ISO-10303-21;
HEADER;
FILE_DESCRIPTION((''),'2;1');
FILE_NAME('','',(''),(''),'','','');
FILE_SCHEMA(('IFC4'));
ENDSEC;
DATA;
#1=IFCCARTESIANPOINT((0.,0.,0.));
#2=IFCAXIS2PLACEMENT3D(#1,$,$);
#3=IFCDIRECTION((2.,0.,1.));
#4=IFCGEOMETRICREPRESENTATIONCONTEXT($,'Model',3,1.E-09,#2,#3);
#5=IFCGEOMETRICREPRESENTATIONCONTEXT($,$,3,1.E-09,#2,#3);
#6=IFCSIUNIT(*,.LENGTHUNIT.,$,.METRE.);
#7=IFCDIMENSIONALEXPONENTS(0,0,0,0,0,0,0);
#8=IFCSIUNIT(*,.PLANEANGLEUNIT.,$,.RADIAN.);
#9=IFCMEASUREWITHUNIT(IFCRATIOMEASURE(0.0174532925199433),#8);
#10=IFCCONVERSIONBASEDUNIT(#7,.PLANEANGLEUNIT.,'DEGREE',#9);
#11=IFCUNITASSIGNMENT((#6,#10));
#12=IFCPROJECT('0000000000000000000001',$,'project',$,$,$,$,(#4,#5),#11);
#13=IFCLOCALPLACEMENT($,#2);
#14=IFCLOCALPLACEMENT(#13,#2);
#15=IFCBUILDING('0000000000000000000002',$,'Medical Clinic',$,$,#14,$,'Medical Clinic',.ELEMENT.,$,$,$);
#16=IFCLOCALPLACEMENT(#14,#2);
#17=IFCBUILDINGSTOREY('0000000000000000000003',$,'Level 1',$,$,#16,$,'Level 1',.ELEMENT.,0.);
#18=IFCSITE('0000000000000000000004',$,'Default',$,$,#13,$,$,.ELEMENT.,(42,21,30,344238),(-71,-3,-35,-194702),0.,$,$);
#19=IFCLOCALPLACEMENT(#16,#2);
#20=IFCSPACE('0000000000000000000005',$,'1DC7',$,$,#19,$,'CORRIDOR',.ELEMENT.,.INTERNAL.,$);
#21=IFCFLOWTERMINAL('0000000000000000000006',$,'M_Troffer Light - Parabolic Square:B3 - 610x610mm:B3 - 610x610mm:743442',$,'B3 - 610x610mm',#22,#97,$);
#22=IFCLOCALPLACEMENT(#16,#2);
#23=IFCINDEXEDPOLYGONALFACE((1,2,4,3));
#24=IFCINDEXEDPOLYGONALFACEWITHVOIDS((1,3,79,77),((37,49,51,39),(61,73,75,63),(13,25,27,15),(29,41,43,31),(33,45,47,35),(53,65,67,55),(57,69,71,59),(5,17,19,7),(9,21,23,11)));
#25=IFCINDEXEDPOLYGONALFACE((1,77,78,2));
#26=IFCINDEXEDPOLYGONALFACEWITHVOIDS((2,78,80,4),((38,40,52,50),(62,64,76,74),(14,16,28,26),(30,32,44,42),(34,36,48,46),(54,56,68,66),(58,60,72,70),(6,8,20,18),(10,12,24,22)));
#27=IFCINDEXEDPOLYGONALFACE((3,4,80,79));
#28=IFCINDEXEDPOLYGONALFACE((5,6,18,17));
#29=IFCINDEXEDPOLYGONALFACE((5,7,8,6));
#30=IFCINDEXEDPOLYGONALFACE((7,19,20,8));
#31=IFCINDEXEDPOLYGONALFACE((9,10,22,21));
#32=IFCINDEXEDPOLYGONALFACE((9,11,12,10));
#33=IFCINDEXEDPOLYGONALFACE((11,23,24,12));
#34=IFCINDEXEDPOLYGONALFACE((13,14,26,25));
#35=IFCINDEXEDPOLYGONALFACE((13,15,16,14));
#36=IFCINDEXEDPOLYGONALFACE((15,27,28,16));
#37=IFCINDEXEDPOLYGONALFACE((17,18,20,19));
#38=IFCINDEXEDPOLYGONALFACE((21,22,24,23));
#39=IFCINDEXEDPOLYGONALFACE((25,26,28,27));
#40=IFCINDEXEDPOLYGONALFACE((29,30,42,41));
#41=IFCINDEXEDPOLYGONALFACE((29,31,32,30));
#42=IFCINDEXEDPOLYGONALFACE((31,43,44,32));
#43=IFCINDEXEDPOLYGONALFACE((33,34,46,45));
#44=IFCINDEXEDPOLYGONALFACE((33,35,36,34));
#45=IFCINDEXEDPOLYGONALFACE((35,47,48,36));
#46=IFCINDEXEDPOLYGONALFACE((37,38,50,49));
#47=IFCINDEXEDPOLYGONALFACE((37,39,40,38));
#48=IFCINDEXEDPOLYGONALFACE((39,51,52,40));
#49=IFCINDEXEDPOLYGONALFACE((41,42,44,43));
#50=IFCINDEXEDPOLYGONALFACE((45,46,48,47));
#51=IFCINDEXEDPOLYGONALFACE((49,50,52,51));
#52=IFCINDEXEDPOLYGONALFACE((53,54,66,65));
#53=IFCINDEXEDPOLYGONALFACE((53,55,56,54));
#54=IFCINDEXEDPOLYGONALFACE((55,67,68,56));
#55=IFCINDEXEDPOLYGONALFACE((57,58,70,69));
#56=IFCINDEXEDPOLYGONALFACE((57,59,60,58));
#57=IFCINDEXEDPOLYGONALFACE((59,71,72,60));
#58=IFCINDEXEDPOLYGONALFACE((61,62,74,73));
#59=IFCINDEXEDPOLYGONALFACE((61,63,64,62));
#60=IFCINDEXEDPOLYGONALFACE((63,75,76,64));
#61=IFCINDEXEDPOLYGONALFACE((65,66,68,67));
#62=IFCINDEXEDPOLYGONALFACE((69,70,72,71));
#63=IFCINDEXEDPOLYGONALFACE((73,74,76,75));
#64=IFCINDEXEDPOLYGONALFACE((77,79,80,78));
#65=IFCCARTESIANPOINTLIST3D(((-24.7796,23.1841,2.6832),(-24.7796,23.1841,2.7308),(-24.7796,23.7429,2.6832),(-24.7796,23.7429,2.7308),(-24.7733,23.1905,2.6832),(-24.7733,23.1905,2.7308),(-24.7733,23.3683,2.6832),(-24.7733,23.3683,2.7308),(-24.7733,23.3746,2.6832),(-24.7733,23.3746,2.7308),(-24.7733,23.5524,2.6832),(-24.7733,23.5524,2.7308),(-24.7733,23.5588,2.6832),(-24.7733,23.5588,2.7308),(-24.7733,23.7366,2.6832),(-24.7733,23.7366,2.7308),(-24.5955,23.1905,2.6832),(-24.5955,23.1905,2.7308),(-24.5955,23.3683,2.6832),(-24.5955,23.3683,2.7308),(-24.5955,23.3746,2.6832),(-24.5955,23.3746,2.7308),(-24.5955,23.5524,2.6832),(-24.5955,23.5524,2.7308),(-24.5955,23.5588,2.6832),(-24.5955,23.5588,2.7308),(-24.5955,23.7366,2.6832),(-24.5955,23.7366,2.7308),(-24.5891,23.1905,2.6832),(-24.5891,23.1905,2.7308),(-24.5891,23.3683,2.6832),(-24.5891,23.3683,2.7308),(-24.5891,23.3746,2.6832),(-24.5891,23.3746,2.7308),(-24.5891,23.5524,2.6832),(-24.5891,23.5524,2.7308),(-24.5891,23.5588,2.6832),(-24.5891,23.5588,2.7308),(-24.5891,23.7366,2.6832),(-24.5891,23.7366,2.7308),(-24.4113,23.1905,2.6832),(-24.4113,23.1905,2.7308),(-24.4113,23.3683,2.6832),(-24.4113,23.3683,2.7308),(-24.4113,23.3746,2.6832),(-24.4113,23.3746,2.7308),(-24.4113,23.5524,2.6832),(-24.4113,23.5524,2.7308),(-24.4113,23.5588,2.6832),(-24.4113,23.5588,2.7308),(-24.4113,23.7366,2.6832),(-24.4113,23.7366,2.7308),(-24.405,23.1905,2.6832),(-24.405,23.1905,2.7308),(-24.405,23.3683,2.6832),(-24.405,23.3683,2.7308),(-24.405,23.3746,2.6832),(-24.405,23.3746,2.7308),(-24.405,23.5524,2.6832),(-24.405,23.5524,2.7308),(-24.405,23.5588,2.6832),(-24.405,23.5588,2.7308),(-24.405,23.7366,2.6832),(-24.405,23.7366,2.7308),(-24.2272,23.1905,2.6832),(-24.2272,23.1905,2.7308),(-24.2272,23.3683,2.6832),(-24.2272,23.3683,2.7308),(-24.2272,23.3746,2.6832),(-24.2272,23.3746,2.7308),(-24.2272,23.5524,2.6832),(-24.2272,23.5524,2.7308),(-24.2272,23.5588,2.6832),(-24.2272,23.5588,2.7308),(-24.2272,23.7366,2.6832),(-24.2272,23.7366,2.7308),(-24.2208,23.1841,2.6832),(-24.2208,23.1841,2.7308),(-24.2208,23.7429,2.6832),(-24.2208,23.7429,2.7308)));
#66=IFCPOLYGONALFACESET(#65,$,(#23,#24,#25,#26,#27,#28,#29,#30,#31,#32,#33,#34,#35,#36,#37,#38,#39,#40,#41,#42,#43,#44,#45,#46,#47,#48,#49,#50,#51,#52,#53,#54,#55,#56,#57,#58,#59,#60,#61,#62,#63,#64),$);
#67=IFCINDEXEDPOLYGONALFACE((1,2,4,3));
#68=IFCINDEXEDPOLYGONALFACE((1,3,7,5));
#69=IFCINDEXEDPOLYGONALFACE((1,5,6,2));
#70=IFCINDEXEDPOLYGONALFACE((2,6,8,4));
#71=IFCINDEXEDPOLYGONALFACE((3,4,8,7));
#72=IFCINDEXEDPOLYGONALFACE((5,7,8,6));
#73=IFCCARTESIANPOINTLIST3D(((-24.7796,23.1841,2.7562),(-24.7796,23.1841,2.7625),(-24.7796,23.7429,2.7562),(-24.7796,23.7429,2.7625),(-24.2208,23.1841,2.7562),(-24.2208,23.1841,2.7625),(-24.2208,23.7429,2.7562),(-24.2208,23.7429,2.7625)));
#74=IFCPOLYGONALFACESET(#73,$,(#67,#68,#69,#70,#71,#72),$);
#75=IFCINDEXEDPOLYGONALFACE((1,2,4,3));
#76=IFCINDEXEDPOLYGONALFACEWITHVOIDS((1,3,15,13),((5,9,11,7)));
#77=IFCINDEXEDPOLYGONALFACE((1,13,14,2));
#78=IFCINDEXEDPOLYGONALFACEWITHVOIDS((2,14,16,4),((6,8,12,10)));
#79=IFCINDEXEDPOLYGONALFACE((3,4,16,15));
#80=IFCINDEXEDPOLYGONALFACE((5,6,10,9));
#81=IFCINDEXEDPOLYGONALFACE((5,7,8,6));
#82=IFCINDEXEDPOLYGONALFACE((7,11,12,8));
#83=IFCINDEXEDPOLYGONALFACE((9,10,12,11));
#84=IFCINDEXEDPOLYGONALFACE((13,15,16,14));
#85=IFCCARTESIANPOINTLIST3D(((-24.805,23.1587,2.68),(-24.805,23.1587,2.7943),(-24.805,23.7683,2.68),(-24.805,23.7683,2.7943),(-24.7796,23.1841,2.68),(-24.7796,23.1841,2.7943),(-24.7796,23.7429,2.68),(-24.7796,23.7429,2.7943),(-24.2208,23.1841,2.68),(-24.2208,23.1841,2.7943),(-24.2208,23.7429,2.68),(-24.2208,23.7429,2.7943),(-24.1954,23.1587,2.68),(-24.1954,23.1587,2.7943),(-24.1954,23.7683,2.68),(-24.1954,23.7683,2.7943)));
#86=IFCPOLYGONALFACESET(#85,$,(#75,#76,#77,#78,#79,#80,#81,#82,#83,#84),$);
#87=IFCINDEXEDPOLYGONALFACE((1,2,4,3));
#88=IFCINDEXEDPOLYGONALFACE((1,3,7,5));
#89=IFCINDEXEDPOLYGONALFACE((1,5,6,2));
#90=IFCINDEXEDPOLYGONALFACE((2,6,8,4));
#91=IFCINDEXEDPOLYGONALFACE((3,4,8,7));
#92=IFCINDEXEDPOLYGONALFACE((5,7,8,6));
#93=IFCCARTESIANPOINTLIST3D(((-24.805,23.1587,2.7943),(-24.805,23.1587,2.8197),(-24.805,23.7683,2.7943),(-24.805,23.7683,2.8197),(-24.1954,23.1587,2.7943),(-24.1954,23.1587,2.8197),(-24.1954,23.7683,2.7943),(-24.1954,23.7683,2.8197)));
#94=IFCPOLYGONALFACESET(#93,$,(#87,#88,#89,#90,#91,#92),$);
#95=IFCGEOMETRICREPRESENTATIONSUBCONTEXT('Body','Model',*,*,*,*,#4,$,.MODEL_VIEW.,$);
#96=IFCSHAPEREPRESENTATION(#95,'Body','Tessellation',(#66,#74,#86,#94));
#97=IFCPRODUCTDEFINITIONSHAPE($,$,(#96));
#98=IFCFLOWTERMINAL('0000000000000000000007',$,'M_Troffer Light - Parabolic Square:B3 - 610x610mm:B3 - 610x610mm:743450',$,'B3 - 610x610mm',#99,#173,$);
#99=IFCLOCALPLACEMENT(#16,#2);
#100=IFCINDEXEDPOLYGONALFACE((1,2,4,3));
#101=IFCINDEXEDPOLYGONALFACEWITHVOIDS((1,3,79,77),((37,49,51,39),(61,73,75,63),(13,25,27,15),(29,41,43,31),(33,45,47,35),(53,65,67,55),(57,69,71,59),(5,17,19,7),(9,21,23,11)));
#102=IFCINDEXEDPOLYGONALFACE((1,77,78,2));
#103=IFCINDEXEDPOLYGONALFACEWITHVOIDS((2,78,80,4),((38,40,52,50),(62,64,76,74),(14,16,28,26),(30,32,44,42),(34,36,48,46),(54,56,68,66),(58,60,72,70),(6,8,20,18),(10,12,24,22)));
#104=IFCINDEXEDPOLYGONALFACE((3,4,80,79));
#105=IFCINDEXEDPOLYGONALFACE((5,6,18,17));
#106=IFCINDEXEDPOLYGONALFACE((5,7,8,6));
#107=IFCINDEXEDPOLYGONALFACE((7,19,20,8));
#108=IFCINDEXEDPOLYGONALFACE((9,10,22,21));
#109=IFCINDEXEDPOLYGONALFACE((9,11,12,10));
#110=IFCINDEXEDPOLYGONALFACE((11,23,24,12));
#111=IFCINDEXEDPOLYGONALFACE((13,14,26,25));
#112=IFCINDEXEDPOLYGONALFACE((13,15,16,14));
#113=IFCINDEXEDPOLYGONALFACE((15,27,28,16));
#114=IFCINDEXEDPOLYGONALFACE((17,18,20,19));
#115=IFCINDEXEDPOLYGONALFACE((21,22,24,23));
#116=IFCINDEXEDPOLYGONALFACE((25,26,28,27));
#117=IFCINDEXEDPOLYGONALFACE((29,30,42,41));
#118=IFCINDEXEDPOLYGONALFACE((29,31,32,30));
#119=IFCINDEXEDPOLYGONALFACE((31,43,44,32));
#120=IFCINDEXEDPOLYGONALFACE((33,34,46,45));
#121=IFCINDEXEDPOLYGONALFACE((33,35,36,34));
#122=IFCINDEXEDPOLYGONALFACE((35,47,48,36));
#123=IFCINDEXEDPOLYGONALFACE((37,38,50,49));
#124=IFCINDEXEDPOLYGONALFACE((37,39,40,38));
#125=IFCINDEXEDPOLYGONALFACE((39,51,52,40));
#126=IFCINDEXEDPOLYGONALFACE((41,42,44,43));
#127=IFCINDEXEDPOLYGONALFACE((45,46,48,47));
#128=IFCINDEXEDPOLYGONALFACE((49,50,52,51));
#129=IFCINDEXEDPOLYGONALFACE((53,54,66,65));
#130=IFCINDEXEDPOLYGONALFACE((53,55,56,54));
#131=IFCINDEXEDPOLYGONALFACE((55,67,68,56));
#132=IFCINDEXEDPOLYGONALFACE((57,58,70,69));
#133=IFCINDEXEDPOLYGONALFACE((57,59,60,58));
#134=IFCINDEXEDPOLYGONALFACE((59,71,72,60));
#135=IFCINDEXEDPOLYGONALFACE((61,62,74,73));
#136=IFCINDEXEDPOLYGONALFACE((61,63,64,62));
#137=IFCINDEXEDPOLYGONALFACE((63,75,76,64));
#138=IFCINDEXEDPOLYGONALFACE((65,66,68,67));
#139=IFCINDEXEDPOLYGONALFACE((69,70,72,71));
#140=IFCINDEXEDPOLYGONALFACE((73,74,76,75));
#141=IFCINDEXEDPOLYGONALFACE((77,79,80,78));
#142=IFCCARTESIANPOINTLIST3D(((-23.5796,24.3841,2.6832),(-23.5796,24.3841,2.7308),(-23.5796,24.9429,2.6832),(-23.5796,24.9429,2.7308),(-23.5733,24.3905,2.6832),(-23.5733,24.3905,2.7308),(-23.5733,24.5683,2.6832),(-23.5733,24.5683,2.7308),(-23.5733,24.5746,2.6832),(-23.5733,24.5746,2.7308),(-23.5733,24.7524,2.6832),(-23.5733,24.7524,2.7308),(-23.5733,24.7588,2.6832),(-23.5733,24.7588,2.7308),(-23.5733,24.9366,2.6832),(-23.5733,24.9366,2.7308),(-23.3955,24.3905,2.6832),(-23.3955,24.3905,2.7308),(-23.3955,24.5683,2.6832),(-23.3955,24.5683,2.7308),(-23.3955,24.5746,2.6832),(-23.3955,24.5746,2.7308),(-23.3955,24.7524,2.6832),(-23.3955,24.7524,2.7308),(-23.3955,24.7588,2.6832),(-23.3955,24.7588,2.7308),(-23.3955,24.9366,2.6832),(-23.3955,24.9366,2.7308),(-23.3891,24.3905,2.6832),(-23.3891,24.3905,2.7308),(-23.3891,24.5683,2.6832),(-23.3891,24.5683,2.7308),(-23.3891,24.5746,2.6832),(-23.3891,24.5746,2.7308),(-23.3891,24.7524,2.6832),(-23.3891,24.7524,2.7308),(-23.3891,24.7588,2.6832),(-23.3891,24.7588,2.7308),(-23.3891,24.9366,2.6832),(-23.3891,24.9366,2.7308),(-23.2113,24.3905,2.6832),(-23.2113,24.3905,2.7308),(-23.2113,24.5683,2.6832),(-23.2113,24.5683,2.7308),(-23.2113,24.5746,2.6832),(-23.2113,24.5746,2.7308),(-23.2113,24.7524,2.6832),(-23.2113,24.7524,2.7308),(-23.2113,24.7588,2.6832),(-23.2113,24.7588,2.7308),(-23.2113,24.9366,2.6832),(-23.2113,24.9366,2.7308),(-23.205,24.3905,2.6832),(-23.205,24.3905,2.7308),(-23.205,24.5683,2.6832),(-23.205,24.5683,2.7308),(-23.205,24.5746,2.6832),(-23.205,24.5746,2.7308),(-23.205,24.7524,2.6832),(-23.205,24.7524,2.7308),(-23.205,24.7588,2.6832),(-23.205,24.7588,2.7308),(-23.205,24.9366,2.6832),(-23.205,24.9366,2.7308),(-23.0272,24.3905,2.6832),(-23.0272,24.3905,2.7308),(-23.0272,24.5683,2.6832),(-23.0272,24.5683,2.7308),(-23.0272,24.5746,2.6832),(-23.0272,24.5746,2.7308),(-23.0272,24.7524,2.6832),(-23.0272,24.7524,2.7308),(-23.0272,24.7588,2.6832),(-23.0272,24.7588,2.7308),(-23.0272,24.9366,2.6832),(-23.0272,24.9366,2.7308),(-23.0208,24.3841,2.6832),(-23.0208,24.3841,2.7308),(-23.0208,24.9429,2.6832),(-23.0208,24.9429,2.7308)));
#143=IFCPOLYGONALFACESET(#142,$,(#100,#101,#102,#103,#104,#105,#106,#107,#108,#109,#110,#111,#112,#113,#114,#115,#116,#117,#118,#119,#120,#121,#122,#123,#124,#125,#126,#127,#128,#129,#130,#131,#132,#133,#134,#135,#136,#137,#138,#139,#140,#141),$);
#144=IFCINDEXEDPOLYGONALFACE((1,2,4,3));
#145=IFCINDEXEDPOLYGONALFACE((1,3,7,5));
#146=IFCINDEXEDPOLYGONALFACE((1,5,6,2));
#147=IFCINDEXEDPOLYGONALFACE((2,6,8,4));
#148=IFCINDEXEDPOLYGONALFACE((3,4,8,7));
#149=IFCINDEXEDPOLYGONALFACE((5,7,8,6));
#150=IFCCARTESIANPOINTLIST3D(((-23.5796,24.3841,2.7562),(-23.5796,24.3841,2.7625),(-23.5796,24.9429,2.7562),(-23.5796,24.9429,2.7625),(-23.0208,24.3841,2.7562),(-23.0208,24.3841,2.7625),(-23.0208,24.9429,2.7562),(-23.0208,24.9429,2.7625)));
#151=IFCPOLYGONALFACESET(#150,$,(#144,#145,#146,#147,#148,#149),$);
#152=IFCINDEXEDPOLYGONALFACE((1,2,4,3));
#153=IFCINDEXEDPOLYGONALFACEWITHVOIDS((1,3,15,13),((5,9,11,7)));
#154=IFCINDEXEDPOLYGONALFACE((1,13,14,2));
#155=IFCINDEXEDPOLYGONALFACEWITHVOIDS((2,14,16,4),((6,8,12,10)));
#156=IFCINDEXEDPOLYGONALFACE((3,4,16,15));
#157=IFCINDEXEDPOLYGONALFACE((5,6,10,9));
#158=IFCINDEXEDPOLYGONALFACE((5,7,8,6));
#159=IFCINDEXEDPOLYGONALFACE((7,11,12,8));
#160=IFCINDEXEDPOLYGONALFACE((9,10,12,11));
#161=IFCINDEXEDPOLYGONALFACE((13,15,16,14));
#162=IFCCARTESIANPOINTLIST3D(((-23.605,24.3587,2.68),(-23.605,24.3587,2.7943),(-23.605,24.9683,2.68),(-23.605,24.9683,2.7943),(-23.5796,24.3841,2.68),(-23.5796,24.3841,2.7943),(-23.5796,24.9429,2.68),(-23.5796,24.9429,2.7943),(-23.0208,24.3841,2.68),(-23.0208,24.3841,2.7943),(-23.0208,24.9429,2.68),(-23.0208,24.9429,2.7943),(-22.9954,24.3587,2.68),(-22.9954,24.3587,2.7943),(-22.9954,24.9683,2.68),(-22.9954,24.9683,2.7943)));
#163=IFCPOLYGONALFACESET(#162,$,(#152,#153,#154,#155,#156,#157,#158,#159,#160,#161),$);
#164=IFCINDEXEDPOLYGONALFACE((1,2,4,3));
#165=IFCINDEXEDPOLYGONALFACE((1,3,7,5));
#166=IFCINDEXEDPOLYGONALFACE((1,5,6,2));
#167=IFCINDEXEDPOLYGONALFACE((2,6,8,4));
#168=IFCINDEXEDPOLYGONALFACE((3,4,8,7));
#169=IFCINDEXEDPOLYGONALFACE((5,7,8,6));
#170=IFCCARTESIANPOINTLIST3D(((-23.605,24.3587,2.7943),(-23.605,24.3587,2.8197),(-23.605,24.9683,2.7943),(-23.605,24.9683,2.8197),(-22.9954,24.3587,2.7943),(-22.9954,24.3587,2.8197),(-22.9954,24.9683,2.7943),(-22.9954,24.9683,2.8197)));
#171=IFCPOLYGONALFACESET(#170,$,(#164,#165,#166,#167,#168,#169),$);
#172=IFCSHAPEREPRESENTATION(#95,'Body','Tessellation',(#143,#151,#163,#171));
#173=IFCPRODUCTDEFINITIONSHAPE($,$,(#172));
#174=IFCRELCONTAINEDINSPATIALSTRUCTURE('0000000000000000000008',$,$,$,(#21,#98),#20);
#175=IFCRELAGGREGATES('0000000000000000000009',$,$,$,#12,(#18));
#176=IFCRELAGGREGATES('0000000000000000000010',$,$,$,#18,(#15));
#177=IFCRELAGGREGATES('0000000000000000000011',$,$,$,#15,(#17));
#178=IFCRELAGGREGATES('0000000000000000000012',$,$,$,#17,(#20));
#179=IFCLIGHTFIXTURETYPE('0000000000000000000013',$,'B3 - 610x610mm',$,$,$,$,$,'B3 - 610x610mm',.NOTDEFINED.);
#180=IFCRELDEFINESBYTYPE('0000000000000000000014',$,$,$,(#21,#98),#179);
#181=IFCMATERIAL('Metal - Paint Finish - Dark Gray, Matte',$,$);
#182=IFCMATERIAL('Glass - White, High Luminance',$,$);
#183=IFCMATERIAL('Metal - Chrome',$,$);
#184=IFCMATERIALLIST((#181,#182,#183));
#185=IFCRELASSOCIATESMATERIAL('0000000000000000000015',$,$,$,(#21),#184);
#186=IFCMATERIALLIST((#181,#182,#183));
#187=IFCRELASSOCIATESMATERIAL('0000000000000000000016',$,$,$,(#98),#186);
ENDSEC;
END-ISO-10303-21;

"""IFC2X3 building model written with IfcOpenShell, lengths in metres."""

from ifc_helpers import new_model, entity, si_unit, converted_unit, direction, frame, origin, origin_2d_with_axis, place, context, subcontext, project, spatial, polyline, rectangle, outline, extrude, source, transform, mapped, material, material_list, type_object, type_shapes, element, save


model = new_model("IFC2X3")

# Units and contexts
model_context = context("Model", 3, precision=1e-09, world=origin(), true_north=direction((2.0, 0.0, 1.0)))
context_of_model = context(None, 3, precision=1e-09, world=origin(), true_north=direction((2.0, 0.0, 1.0)))
body_context = subcontext(model_context, "Body", "Model", "MODEL_VIEW")
ifc_project = project(units=[si_unit("LENGTHUNIT", "METRE"), converted_unit("PLANEANGLEUNIT", "DEGREE", entity("IfcRatioMeasure", 0.0174532925199433), si_unit("PLANEANGLEUNIT", "RADIAN"), dimensions=[0, 0, 0, 0, 0, 0, 0])], contexts=[model_context, context_of_model])

# Site, building, storey, space
site_placement = place(None, origin())
site = spatial("IfcSite", under=ifc_project, at=site_placement, Name="Default", CompositionType="ELEMENT", RefLatitude=(42, 21, 30, 344238), RefLongitude=(-71, -3, -35, -194702), RefElevation=0.0)
building_placement = place(site_placement, origin())
building = spatial("IfcBuilding", under=site, at=building_placement, Name="Medical Clinic", LongName="Medical Clinic", CompositionType="ELEMENT")
storey_placement = place(building_placement, origin())
storey = spatial("IfcBuildingStorey", under=building, at=storey_placement, Name="Level 1", LongName="Level 1", CompositionType="ELEMENT", Elevation=0.0)
space_1_placement = place(storey_placement, origin())
space_1 = spatial("IfcSpace", under=storey, at=space_1_placement, Name="1DC7", LongName="CORRIDOR", CompositionType="ELEMENT", InteriorOrExteriorSpace="INTERNAL")

# Flow terminals
ifc_material_1 = material(Name="Metal - Paint Finish - Dark Gray, Matte")
ifc_material_2 = material(Name="Glass - White, High Luminance")
ifc_material_3 = material(Name="Metal - Chrome")
ifc_material_list_1 = material_list([ifc_material_1, ifc_material_2, ifc_material_3])
light_fixture_type_1 = type_object("IfcLightFixtureType", Name="B3 - 610x610mm", ElementType="B3 - 610x610mm", PredefinedType="NOTDEFINED")
shared_shape_1 = source(origin(), body_context, "Body", "SweptSolid", [
    extrude(outline(polyline([(-0.2794, -0.2794), (0.2794, -0.2794), (0.2794, 0.2794), (-0.2794, 0.2794), (-0.2794, -0.2794)]), holes=[polyline([(-0.0952, 0.0953), (-0.273, 0.0953), (-0.273, 0.2731), (-0.0952, 0.2731), (-0.0952, 0.0953)]), polyline([(0.2731, 0.0953), (0.0953, 0.0953), (0.0953, 0.2731), (0.2731, 0.2731), (0.2731, 0.0953)]), polyline([(-0.0889, 0.2731), (0.0889, 0.2731), (0.0889, 0.0953), (-0.0889, 0.0953), (-0.0889, 0.2731)]), polyline([(0.2731, -0.273), (0.0953, -0.273), (0.0953, -0.0952), (0.2731, -0.0952), (0.2731, -0.273)]), polyline([(0.0889, -0.273), (-0.0889, -0.273), (-0.0889, -0.0952), (0.0889, -0.0952), (0.0889, -0.273)]), polyline([(-0.0952, -0.273), (-0.273, -0.273), (-0.273, -0.0952), (-0.0952, -0.0952), (-0.0952, -0.273)]), polyline([(-0.0952, -0.0889), (-0.273, -0.0889), (-0.273, 0.0889), (-0.0952, 0.0889), (-0.0952, -0.0889)]), polyline([(0.0889, -0.0889), (-0.0889, -0.0889), (-0.0889, 0.0889), (0.0889, 0.0889), (0.0889, -0.0889)]), polyline([(0.2731, -0.0889), (0.0953, -0.0889), (0.0953, 0.0889), (0.2731, 0.0889), (0.2731, -0.0889)])]), frame((0.0, -0.3048, -0.0508), z_axis=(0.0, 0.0, 1.0), x_axis=(-1.0, 0.0, 0.0)), (0.0, 0.0, 1.0), 0.0476),
    extrude(rectangle(XDim=0.5588, YDim=0.5588, at=origin_2d_with_axis()), frame((0.0, -0.3048, -0.0825), z_axis=(0.0, 0.0, 1.0), x_axis=(-1.0, 0.0, 0.0)), (0.0, 0.0, 1.0), 0.0064),
    extrude(outline(polyline([(-0.3048, -0.3048), (0.3048, -0.3048), (0.3048, 0.3048), (-0.3048, 0.3048), (-0.3048, -0.3048)]), holes=[polyline([(0.2794, 0.2794), (0.2794, -0.2794), (-0.2794, -0.2794), (-0.2794, 0.2794), (0.2794, 0.2794)])]), frame((0.0, -0.3048, -0.1143)), (0.0, 0.0, 1.0), 0.1143),
    extrude(rectangle(XDim=0.6096, YDim=0.6096, at=origin_2d_with_axis()), frame((0.0, -0.3048, -0.1397), z_axis=(0.0, 0.0, 1.0), x_axis=(-1.0, 0.0, 0.0)), (0.0, 0.0, 1.0), 0.0254),
])
type_shapes(light_fixture_type_1, [shared_shape_1])
flow_terminal_1_placement = place(space_1_placement, frame((-24.5002, 23.1587, 2.68), z_axis=(0.0, 0.0, -1.0), x_axis=(1.0, 0.0, 0.0)))
element("IfcFlowTerminal", 1, at=flow_terminal_1_placement, inside=space_1, type_object=light_fixture_type_1, material=ifc_material_list_1, Name="M_Troffer Light - Parabolic Square:B3 - 610x610mm:B3 - 610x610mm:743442", ObjectType="B3 - 610x610mm", context=body_context, shape_type="MappedRepresentation", body=[
    mapped(shared_shape_1, transform((0.0, 0.0, 0.0), scale=1.0)),
])
ifc_material_list_2 = material_list([ifc_material_1, ifc_material_2, ifc_material_3])
flow_terminal_2_placement = place(space_1_placement, frame((-23.3002, 24.3587, 2.68), z_axis=(0.0, 0.0, -1.0), x_axis=(1.0, 0.0, 0.0)))
element("IfcFlowTerminal", 2, at=flow_terminal_2_placement, inside=space_1, type_object=light_fixture_type_1, material=ifc_material_list_2, Name="M_Troffer Light - Parabolic Square:B3 - 610x610mm:B3 - 610x610mm:743450", ObjectType="B3 - 610x610mm", context=body_context, shape_type="MappedRepresentation", body=[
    mapped(shared_shape_1, transform((0.0, 0.0, 0.0), scale=1.0)),
])

save(model, "model.ifc")
